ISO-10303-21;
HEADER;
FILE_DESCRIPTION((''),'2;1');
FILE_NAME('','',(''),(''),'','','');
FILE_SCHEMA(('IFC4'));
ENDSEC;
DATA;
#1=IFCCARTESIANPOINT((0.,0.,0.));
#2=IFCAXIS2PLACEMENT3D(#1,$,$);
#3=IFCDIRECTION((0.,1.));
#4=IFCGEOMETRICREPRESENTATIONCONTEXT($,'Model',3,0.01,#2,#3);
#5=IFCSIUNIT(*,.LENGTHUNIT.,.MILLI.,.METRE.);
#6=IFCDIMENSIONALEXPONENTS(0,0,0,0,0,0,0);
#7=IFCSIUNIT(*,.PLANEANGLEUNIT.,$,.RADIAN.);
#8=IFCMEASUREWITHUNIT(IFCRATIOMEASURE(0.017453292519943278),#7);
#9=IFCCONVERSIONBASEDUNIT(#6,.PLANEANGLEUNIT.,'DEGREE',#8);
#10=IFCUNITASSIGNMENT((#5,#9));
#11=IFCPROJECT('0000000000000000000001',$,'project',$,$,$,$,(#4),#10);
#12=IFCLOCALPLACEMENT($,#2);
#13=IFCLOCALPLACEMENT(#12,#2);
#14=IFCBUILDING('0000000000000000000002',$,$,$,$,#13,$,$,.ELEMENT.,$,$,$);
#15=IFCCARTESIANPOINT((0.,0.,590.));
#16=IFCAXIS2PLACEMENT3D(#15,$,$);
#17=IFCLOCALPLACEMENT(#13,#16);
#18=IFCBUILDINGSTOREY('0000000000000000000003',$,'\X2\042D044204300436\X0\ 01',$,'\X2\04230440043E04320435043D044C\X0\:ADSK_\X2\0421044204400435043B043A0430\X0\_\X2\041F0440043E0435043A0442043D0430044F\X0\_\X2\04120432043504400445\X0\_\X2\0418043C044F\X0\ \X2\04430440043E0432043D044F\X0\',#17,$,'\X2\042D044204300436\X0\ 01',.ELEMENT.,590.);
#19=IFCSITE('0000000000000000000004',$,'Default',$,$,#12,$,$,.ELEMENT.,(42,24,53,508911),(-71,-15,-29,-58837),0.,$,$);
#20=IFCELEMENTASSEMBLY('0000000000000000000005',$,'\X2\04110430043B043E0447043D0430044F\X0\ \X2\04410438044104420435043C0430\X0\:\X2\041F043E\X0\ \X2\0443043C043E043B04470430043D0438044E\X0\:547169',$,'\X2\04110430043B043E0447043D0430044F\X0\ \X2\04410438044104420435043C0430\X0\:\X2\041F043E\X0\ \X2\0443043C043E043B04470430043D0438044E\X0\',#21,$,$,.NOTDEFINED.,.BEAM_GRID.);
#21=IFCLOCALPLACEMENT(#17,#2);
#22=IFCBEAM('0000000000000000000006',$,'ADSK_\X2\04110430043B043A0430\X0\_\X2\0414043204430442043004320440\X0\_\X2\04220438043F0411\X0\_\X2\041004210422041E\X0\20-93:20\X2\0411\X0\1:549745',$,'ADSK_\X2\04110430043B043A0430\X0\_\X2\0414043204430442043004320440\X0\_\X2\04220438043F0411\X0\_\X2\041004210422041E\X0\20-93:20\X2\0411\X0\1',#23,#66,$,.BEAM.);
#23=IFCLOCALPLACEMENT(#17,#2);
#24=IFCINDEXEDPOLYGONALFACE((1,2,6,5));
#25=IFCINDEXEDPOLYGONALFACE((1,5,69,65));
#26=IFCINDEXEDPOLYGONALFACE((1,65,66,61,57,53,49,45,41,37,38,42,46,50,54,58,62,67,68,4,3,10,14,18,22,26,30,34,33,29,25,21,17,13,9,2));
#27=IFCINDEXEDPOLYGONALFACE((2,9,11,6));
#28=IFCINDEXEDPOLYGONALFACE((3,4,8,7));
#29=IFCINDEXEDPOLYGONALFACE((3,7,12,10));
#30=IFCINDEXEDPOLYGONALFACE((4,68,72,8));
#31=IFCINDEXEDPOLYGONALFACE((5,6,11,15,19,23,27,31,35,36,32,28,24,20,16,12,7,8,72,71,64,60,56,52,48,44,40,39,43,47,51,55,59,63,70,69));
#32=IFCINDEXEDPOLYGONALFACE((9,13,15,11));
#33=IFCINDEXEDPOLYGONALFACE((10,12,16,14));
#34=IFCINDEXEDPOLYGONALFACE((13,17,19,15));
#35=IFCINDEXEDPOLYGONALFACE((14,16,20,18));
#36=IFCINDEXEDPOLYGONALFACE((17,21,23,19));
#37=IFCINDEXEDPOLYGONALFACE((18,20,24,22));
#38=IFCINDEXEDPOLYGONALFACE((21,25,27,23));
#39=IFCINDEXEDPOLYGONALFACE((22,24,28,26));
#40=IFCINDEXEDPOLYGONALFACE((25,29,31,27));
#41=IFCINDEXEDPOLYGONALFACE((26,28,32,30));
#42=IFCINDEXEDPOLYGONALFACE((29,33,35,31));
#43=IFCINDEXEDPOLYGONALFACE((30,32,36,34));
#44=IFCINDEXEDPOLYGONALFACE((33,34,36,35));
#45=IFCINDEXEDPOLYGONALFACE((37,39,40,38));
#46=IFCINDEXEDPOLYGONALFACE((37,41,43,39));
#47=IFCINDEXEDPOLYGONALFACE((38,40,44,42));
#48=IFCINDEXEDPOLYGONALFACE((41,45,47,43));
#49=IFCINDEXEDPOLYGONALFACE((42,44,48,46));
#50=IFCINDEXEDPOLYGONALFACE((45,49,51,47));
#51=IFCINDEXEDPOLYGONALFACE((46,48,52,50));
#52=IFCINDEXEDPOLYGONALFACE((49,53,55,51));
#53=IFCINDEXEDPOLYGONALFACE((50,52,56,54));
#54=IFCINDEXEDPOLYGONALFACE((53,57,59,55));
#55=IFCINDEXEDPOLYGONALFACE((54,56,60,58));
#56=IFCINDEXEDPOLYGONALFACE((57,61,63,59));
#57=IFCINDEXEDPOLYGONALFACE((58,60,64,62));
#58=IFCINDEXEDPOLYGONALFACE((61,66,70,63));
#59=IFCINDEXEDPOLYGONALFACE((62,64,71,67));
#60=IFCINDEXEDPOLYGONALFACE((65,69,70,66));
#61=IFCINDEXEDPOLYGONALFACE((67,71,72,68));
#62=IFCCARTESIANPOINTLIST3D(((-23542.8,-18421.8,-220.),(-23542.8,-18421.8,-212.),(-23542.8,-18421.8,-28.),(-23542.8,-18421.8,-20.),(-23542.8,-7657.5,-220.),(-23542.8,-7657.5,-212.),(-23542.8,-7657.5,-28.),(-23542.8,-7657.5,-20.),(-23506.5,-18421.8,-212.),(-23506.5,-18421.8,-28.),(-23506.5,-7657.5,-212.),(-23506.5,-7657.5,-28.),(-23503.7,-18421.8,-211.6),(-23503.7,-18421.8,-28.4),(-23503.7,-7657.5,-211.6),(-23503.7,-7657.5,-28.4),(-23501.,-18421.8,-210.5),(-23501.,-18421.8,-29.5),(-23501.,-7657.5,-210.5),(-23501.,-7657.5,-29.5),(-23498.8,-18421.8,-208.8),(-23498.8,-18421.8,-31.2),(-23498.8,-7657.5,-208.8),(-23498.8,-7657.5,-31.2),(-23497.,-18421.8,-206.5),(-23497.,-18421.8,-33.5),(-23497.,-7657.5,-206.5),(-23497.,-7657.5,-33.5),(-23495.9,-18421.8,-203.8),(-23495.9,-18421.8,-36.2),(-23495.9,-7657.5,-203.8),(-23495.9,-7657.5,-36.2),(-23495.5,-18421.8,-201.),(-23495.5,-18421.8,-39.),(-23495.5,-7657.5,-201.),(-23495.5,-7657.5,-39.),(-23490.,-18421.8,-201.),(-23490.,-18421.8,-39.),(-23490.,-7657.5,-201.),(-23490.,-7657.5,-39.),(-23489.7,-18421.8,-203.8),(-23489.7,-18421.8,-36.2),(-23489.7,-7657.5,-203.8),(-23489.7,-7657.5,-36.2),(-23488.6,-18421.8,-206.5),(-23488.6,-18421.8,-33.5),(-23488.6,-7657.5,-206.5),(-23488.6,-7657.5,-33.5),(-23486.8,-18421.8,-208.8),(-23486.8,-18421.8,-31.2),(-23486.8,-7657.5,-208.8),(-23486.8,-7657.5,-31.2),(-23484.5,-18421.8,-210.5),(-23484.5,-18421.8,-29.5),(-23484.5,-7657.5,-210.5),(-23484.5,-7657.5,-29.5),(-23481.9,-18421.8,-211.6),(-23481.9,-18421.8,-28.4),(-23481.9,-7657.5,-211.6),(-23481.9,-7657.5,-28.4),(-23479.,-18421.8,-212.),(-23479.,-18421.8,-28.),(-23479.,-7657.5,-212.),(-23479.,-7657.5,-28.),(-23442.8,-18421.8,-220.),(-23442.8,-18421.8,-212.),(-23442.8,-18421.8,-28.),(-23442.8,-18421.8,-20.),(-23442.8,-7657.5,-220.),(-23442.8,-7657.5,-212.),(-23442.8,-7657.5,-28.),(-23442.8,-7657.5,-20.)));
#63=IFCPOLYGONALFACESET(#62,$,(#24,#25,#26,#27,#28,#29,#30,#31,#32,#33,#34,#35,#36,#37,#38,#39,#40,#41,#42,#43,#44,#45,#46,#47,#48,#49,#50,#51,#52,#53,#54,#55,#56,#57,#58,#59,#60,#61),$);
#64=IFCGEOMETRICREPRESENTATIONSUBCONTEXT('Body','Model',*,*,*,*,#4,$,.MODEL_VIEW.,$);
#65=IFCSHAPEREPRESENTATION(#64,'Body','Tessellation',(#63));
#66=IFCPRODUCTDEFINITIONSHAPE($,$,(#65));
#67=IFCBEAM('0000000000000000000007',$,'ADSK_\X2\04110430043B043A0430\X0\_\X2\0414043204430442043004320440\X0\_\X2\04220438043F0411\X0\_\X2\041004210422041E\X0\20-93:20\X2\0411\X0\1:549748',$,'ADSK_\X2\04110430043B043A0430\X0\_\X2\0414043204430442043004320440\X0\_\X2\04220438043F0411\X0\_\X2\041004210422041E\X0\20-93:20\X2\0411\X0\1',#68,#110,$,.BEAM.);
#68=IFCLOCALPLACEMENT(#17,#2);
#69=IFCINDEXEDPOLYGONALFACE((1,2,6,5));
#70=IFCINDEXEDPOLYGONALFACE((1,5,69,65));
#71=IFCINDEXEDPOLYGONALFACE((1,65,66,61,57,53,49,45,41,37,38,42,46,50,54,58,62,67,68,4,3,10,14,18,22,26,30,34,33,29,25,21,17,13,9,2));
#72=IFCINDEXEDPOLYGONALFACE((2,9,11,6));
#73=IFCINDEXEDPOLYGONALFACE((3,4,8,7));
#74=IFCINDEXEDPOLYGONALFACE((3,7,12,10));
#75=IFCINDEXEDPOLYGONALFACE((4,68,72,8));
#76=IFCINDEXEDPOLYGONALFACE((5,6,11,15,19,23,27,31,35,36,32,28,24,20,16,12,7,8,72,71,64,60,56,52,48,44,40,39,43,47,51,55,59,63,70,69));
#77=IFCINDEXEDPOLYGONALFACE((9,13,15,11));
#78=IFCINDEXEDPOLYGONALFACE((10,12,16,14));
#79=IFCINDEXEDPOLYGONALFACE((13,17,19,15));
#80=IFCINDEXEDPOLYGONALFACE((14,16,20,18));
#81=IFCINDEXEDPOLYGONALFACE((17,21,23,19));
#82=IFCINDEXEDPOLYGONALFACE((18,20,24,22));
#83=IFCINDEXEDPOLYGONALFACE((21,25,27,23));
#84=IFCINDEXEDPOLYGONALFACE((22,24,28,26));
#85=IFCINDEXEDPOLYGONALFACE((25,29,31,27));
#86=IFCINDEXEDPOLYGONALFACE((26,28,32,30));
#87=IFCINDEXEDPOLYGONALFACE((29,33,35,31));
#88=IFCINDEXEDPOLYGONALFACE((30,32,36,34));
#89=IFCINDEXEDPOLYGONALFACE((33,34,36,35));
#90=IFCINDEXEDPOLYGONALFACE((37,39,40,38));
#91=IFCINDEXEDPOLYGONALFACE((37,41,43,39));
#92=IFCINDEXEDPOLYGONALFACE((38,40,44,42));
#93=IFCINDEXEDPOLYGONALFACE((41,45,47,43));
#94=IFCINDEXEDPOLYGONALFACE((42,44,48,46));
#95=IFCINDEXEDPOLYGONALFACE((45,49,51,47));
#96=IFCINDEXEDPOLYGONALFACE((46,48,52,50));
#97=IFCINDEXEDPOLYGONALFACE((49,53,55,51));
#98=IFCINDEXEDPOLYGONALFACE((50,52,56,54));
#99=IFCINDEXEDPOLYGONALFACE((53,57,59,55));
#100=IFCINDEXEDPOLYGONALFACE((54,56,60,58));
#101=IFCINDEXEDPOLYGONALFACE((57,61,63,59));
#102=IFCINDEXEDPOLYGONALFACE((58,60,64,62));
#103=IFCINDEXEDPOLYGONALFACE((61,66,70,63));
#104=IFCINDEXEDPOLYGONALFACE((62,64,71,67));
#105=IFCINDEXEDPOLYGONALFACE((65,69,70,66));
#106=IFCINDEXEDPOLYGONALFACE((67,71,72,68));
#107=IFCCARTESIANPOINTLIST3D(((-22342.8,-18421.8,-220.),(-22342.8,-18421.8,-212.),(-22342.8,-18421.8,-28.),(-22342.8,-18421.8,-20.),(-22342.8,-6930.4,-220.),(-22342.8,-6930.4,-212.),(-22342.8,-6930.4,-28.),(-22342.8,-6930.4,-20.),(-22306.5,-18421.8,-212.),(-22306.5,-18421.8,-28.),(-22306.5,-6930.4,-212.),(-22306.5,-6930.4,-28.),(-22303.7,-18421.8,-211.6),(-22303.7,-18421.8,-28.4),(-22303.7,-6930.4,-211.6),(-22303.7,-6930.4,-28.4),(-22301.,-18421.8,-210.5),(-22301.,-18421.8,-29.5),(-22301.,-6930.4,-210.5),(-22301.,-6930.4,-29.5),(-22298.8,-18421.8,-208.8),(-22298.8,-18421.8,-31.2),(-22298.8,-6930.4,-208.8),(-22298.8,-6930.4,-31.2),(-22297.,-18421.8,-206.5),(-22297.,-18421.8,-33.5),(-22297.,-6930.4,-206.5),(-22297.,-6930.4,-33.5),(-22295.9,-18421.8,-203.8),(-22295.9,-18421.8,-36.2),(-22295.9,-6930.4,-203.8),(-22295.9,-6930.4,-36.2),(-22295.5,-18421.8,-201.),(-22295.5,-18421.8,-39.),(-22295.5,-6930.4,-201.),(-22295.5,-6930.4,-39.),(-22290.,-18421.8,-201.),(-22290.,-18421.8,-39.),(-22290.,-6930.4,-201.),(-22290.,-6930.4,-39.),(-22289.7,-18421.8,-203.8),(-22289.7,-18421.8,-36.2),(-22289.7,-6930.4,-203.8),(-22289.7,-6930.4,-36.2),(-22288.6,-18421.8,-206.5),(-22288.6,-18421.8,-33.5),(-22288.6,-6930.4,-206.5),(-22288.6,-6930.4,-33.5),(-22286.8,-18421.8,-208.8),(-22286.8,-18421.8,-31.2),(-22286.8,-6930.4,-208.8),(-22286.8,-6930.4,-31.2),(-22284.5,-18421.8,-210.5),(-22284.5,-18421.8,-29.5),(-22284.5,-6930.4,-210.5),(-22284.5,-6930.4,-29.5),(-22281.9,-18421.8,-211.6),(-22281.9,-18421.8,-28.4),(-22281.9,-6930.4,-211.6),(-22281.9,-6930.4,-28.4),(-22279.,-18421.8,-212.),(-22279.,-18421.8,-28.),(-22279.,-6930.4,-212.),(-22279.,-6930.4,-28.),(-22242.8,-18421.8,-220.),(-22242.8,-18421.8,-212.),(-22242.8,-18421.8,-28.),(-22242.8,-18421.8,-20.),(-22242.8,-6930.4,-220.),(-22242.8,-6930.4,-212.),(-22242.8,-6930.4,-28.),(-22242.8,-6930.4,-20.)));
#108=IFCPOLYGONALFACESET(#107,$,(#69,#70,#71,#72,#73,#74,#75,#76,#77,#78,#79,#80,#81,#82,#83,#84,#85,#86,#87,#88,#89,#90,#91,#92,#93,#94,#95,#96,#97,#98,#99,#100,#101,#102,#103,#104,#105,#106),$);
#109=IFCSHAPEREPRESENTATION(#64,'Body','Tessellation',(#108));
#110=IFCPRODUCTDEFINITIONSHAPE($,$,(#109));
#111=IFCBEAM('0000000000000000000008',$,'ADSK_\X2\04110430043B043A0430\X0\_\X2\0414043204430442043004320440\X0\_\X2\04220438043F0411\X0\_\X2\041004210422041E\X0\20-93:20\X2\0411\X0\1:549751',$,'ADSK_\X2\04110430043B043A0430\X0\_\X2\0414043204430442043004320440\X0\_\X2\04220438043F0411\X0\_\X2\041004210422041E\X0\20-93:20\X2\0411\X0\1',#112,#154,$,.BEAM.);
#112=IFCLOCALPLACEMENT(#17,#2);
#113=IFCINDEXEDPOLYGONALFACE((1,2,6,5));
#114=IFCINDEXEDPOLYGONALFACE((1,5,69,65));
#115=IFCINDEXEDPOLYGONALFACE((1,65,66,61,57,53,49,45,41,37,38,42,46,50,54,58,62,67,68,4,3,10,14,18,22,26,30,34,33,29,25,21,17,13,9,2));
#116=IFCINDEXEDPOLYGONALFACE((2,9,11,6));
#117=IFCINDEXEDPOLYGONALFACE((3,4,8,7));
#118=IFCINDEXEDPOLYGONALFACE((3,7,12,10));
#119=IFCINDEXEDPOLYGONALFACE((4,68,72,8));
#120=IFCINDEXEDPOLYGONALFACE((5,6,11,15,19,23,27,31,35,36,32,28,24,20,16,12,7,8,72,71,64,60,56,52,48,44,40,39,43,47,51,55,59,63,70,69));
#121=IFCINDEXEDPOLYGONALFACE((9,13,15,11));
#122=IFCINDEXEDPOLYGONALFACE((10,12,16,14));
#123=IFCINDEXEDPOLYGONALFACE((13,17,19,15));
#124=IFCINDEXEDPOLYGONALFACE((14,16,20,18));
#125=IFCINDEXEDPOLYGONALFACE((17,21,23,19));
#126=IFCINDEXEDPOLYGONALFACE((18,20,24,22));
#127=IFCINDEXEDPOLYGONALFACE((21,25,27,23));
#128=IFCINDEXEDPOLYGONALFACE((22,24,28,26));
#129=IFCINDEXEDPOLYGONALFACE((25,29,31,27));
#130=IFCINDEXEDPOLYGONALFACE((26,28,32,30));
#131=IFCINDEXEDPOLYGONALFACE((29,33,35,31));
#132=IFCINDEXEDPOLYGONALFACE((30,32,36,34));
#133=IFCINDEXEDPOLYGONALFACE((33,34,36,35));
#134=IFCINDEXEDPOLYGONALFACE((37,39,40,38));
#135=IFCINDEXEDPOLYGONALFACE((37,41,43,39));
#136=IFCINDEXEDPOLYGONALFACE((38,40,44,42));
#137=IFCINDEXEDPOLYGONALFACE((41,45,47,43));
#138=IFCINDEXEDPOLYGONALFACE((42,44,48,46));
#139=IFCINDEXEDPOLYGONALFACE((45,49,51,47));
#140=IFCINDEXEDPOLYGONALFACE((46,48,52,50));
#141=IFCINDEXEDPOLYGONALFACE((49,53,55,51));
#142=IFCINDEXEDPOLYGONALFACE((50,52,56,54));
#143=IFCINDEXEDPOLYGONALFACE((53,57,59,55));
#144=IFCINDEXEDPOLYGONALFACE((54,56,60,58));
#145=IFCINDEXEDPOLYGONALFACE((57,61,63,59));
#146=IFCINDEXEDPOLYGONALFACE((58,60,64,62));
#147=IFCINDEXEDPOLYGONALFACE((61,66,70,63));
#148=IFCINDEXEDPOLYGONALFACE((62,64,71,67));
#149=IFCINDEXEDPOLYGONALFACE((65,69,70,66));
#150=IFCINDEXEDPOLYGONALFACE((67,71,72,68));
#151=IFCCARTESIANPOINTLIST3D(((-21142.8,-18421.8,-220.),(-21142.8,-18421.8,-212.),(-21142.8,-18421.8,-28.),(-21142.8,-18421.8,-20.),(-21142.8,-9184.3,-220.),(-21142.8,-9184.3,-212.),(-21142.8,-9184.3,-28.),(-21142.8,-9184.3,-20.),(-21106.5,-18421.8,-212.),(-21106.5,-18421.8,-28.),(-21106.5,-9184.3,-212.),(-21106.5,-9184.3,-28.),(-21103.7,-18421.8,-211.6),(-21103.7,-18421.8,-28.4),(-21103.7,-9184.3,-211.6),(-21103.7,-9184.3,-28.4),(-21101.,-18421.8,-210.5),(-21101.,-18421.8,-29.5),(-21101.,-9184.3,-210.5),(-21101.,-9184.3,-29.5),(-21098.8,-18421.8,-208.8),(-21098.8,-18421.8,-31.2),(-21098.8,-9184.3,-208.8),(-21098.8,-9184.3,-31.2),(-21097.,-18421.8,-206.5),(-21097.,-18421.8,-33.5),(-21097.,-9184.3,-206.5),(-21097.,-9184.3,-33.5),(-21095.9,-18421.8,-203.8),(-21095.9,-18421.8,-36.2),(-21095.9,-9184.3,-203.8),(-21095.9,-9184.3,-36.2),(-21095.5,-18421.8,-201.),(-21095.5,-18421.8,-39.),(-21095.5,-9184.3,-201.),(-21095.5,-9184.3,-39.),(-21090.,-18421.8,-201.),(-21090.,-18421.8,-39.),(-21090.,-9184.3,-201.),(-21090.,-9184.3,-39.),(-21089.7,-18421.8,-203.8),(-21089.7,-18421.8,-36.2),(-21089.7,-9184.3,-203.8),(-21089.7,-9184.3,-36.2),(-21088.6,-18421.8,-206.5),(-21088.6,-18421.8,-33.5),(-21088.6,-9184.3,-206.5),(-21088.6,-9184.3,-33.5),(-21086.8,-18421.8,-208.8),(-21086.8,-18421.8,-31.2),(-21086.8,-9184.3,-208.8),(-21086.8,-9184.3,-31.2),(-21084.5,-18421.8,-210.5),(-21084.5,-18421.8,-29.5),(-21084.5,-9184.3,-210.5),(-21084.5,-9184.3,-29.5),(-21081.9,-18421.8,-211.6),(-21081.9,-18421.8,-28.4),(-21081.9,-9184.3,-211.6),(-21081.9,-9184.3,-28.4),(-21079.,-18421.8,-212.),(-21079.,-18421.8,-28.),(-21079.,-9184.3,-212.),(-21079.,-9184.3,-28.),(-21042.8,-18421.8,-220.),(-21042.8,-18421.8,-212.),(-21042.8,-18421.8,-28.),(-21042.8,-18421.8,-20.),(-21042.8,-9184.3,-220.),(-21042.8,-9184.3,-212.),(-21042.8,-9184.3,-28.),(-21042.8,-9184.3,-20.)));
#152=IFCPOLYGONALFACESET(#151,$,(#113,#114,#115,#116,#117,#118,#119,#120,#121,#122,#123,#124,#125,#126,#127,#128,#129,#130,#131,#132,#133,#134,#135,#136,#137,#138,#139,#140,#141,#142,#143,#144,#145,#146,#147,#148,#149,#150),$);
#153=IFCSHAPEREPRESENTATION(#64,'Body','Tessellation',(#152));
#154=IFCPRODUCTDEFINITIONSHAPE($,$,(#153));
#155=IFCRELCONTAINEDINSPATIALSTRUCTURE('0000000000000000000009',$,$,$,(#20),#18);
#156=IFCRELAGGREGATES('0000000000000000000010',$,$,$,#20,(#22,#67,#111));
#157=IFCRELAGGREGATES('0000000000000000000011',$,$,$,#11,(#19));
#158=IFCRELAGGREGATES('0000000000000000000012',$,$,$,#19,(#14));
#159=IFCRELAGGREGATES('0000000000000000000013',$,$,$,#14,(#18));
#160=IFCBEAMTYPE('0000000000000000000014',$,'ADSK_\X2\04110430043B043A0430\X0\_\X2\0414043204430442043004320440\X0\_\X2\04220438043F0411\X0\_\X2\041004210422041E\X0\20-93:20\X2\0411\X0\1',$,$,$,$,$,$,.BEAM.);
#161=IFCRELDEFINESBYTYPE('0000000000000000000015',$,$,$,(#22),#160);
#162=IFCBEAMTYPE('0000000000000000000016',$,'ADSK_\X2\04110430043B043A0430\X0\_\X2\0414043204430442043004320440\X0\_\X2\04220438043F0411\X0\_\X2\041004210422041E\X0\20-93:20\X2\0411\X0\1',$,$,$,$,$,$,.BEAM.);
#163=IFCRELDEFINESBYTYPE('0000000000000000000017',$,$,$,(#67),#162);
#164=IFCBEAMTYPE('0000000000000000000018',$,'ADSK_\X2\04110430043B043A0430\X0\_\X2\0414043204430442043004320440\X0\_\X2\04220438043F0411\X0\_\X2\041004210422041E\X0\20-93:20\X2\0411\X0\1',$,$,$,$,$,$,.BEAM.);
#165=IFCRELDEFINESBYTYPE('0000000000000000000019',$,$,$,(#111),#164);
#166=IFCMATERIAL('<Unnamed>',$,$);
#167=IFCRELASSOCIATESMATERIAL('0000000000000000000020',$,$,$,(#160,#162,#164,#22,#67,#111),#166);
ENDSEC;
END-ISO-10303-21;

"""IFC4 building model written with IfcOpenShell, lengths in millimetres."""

from ifc_helpers import new_model, entity, si_unit, converted_unit, direction, frame, frame_2d, origin, place, context, subcontext, project, spatial, polyline, circle_curve, parameter, trimmed, segment, composite_curve, i_section, outline, extrude, source, transform, mapped, material, material_profile, profile_set, profile_usage, type_object, type_shapes, element, aggregate, save


model = new_model("IFC4")

# Units and contexts
model_context = context("Model", 3, precision=0.01, world=origin(), true_north=direction((0.0, 1.0)))
body_context = subcontext(model_context, "Body", "Model", "MODEL_VIEW")
ifc_project = project(units=[si_unit("LENGTHUNIT", "METRE", prefix="MILLI"), converted_unit("PLANEANGLEUNIT", "DEGREE", entity("IfcRatioMeasure", 0.017453292519943278), si_unit("PLANEANGLEUNIT", "RADIAN"), dimensions=[0, 0, 0, 0, 0, 0, 0])], contexts=[model_context])

# Site, building, storey
site_placement = place(None, origin())
site = spatial("IfcSite", under=ifc_project, at=site_placement, Name="Default", CompositionType="ELEMENT", RefLatitude=(42, 24, 53, 508911), RefLongitude=(-71, -15, -29, -58837), RefElevation=0.0)
building_placement = place(site_placement, origin())
building = spatial("IfcBuilding", under=site, at=building_placement, CompositionType="ELEMENT")
storey_placement = place(building_placement, frame((0.0, 0.0, 590.0)))
storey = spatial("IfcBuildingStorey", under=building, at=storey_placement, Name="Этаж 01", ObjectType="Уровень:ADSK_Стрелка_Проектная_Вверх_Имя уровня", LongName="Этаж 01", CompositionType="ELEMENT", Elevation=590.0)

# Shared definitions
ifc_material_1 = material(Name="<Unnamed>")

# Element assembly, beams
assembly_placement = place(storey_placement, origin())
assembly = element("IfcElementAssembly", 1, at=assembly_placement, inside=storey, Name="Балочная система:По умолчанию:547169", ObjectType="Балочная система:По умолчанию", AssemblyPlace="NOTDEFINED", PredefinedType="BEAM_GRID")
ifc_material_profile_1 = material_profile(ifc_material_1, outline(composite_curve([segment(polyline([(13.7, -192.0, 0.0), (50.0, -192.0, 0.0)]), True, "CONTINUOUS"), segment(polyline([(50.0, -192.0, 0.0), (50.0, -200.0, 0.0)]), True, "CONTINUOUS"), segment(polyline([(50.0, -200.0, 0.0), (-50.0, -200.0, 0.0)]), True, "CONTINUOUS"), segment(polyline([(-50.0, -200.0, 0.0), (-50.0, -192.0, 0.0)]), True, "CONTINUOUS"), segment(polyline([(-50.0, -192.0, 0.0), (-13.8, -192.0, 0.0)]), True, "CONTINUOUS"), segment(trimmed(circle_curve(frame((-13.8, -181.0, 0.0), z_axis=(0.0, 0.0, 1.0), x_axis=(-1.0, 0.0, 0.0)), 11.0), [parameter(90.0)], [parameter(180.0)], True, "PARAMETER"), True, "CONTINUOUS"), segment(polyline([(-2.8, -181.0, 0.0), (-2.8, -19.0, 0.0)]), True, "CONTINUOUS"), segment(trimmed(circle_curve(frame((-13.8, -19.0, 0.0), z_axis=(0.0, 0.0, 1.0), x_axis=(-1.0, 0.0, 0.0)), 11.0), [parameter(180.0)], [parameter(270.0)], True, "PARAMETER"), True, "CONTINUOUS"), segment(polyline([(-13.8, -8.0, 0.0), (-50.0, -8.0, 0.0)]), True, "CONTINUOUS"), segment(polyline([(-50.0, -8.0, 0.0), (-50.0, 0.0, 0.0)]), True, "CONTINUOUS"), segment(polyline([(-50.0, 0.0, 0.0), (50.0, 0.0, 0.0)]), True, "CONTINUOUS"), segment(polyline([(50.0, 0.0, 0.0), (50.0, -8.0, 0.0)]), True, "CONTINUOUS"), segment(polyline([(50.0, -8.0, 0.0), (13.7, -8.0, 0.0)]), True, "CONTINUOUS"), segment(trimmed(circle_curve(frame((13.7, -19.0, 0.0), z_axis=(0.0, 0.0, 1.0), x_axis=(-1.0, 0.0, 0.0)), 11.0), [parameter(270.0)], [parameter(0.0)], True, "PARAMETER"), True, "CONTINUOUS"), segment(polyline([(2.7, -19.0, 0.0), (2.7, -181.0, 0.0)]), True, "CONTINUOUS"), segment(trimmed(circle_curve(frame((13.7, -181.0, 0.0), z_axis=(0.0, 0.0, 1.0), x_axis=(-1.0, 0.0, 0.0)), 11.0), [parameter(0.0)], [parameter(90.0)], True, "PARAMETER"), True, "CONTINUOUS")], self_intersect=False), kind="CURVE"), Name="20Б1")
ifc_profile_set_1 = profile_set([ifc_material_profile_1], Name="20Б1")
ifc_profile_usage_1 = profile_usage(ifc_profile_set_1, cardinal=8)
beam_type_1 = type_object("IfcBeamType", Name="ADSK_Балка_Двутавр_ТипБ_АСТО20-93:20Б1", PredefinedType="BEAM", material=ifc_profile_set_1)
shared_shape_1 = source(origin(), body_context, "Body", "SweptSolid", [
    extrude(i_section(OverallWidth=100.0, OverallDepth=200.0, WebThickness=5.5, FlangeThickness=8.0, FilletRadius=11.0, at=frame_2d((0.0, 0.0), x_axis=(0.0, 1.0))), frame((-5382.1, 0.0, -100.0), z_axis=(1.0, 0.0, 0.0), x_axis=(0.0, 0.0, -1.0)), (0.0, 0.0, 1.0), 10764.3),
])
type_shapes(beam_type_1, [shared_shape_1])
beam_1_placement = place(assembly_placement, frame((-23492.8, -13039.7, -20.0), z_axis=(0.0, 0.0, 1.0), x_axis=(0.0, 1.0, 0.0)))
beam_1 = element("IfcBeam", 2, at=beam_1_placement, type_object=beam_type_1, material=ifc_profile_usage_1, Name="ADSK_Балка_Двутавр_ТипБ_АСТО20-93:20Б1:549745", ObjectType="ADSK_Балка_Двутавр_ТипБ_АСТО20-93:20Б1", PredefinedType="BEAM", context=body_context, shape_type="MappedRepresentation", body=[
    mapped(shared_shape_1, transform((0.0, 0.0, 0.0), scale=1.0)),
])
ifc_profile_usage_2 = profile_usage(ifc_profile_set_1, cardinal=8)
beam_type_2 = type_object("IfcBeamType", Name="ADSK_Балка_Двутавр_ТипБ_АСТО20-93:20Б1", PredefinedType="BEAM", material=ifc_profile_set_1)
shared_shape_2 = source(origin(), body_context, "Body", "SweptSolid", [
    extrude(i_section(OverallWidth=100.0, OverallDepth=200.0, WebThickness=5.5, FlangeThickness=8.0, FilletRadius=11.0, at=frame_2d((0.0, 0.0), x_axis=(0.0, 1.0))), frame((-5745.7, 0.0, -100.0), z_axis=(1.0, 0.0, 0.0), x_axis=(0.0, 0.0, -1.0)), (0.0, 0.0, 1.0), 11491.4),
])
type_shapes(beam_type_2, [shared_shape_2])
beam_2_placement = place(assembly_placement, frame((-22292.8, -12676.1, -20.0), z_axis=(0.0, 0.0, 1.0), x_axis=(0.0, 1.0, 0.0)))
beam_2 = element("IfcBeam", 3, at=beam_2_placement, type_object=beam_type_2, material=ifc_profile_usage_2, Name="ADSK_Балка_Двутавр_ТипБ_АСТО20-93:20Б1:549748", ObjectType="ADSK_Балка_Двутавр_ТипБ_АСТО20-93:20Б1", PredefinedType="BEAM", context=body_context, shape_type="MappedRepresentation", body=[
    mapped(shared_shape_2, transform((0.0, 0.0, 0.0), scale=1.0)),
])
ifc_profile_usage_3 = profile_usage(ifc_profile_set_1, cardinal=8)
beam_type_3 = type_object("IfcBeamType", Name="ADSK_Балка_Двутавр_ТипБ_АСТО20-93:20Б1", PredefinedType="BEAM", material=ifc_profile_set_1)
shared_shape_3 = source(origin(), body_context, "Body", "SweptSolid", [
    extrude(i_section(OverallWidth=100.0, OverallDepth=200.0, WebThickness=5.5, FlangeThickness=8.0, FilletRadius=11.0, at=frame_2d((0.0, 0.0), x_axis=(0.0, 1.0))), frame((-4618.7, 0.0, -100.0), z_axis=(1.0, 0.0, 0.0), x_axis=(0.0, 0.0, -1.0)), (0.0, 0.0, 1.0), 9237.5),
])
type_shapes(beam_type_3, [shared_shape_3])
beam_3_placement = place(assembly_placement, frame((-21092.8, -13803.0, -20.0), z_axis=(0.0, 0.0, 1.0), x_axis=(0.0, 1.0, 0.0)))
beam_3 = element("IfcBeam", 4, at=beam_3_placement, type_object=beam_type_3, material=ifc_profile_usage_3, Name="ADSK_Балка_Двутавр_ТипБ_АСТО20-93:20Б1:549751", ObjectType="ADSK_Балка_Двутавр_ТипБ_АСТО20-93:20Б1", PredefinedType="BEAM", context=body_context, shape_type="MappedRepresentation", body=[
    mapped(shared_shape_3, transform((0.0, 0.0, 0.0), scale=1.0)),
])
aggregate(assembly, [beam_1, beam_2, beam_3])

save(model, "model.ifc")
